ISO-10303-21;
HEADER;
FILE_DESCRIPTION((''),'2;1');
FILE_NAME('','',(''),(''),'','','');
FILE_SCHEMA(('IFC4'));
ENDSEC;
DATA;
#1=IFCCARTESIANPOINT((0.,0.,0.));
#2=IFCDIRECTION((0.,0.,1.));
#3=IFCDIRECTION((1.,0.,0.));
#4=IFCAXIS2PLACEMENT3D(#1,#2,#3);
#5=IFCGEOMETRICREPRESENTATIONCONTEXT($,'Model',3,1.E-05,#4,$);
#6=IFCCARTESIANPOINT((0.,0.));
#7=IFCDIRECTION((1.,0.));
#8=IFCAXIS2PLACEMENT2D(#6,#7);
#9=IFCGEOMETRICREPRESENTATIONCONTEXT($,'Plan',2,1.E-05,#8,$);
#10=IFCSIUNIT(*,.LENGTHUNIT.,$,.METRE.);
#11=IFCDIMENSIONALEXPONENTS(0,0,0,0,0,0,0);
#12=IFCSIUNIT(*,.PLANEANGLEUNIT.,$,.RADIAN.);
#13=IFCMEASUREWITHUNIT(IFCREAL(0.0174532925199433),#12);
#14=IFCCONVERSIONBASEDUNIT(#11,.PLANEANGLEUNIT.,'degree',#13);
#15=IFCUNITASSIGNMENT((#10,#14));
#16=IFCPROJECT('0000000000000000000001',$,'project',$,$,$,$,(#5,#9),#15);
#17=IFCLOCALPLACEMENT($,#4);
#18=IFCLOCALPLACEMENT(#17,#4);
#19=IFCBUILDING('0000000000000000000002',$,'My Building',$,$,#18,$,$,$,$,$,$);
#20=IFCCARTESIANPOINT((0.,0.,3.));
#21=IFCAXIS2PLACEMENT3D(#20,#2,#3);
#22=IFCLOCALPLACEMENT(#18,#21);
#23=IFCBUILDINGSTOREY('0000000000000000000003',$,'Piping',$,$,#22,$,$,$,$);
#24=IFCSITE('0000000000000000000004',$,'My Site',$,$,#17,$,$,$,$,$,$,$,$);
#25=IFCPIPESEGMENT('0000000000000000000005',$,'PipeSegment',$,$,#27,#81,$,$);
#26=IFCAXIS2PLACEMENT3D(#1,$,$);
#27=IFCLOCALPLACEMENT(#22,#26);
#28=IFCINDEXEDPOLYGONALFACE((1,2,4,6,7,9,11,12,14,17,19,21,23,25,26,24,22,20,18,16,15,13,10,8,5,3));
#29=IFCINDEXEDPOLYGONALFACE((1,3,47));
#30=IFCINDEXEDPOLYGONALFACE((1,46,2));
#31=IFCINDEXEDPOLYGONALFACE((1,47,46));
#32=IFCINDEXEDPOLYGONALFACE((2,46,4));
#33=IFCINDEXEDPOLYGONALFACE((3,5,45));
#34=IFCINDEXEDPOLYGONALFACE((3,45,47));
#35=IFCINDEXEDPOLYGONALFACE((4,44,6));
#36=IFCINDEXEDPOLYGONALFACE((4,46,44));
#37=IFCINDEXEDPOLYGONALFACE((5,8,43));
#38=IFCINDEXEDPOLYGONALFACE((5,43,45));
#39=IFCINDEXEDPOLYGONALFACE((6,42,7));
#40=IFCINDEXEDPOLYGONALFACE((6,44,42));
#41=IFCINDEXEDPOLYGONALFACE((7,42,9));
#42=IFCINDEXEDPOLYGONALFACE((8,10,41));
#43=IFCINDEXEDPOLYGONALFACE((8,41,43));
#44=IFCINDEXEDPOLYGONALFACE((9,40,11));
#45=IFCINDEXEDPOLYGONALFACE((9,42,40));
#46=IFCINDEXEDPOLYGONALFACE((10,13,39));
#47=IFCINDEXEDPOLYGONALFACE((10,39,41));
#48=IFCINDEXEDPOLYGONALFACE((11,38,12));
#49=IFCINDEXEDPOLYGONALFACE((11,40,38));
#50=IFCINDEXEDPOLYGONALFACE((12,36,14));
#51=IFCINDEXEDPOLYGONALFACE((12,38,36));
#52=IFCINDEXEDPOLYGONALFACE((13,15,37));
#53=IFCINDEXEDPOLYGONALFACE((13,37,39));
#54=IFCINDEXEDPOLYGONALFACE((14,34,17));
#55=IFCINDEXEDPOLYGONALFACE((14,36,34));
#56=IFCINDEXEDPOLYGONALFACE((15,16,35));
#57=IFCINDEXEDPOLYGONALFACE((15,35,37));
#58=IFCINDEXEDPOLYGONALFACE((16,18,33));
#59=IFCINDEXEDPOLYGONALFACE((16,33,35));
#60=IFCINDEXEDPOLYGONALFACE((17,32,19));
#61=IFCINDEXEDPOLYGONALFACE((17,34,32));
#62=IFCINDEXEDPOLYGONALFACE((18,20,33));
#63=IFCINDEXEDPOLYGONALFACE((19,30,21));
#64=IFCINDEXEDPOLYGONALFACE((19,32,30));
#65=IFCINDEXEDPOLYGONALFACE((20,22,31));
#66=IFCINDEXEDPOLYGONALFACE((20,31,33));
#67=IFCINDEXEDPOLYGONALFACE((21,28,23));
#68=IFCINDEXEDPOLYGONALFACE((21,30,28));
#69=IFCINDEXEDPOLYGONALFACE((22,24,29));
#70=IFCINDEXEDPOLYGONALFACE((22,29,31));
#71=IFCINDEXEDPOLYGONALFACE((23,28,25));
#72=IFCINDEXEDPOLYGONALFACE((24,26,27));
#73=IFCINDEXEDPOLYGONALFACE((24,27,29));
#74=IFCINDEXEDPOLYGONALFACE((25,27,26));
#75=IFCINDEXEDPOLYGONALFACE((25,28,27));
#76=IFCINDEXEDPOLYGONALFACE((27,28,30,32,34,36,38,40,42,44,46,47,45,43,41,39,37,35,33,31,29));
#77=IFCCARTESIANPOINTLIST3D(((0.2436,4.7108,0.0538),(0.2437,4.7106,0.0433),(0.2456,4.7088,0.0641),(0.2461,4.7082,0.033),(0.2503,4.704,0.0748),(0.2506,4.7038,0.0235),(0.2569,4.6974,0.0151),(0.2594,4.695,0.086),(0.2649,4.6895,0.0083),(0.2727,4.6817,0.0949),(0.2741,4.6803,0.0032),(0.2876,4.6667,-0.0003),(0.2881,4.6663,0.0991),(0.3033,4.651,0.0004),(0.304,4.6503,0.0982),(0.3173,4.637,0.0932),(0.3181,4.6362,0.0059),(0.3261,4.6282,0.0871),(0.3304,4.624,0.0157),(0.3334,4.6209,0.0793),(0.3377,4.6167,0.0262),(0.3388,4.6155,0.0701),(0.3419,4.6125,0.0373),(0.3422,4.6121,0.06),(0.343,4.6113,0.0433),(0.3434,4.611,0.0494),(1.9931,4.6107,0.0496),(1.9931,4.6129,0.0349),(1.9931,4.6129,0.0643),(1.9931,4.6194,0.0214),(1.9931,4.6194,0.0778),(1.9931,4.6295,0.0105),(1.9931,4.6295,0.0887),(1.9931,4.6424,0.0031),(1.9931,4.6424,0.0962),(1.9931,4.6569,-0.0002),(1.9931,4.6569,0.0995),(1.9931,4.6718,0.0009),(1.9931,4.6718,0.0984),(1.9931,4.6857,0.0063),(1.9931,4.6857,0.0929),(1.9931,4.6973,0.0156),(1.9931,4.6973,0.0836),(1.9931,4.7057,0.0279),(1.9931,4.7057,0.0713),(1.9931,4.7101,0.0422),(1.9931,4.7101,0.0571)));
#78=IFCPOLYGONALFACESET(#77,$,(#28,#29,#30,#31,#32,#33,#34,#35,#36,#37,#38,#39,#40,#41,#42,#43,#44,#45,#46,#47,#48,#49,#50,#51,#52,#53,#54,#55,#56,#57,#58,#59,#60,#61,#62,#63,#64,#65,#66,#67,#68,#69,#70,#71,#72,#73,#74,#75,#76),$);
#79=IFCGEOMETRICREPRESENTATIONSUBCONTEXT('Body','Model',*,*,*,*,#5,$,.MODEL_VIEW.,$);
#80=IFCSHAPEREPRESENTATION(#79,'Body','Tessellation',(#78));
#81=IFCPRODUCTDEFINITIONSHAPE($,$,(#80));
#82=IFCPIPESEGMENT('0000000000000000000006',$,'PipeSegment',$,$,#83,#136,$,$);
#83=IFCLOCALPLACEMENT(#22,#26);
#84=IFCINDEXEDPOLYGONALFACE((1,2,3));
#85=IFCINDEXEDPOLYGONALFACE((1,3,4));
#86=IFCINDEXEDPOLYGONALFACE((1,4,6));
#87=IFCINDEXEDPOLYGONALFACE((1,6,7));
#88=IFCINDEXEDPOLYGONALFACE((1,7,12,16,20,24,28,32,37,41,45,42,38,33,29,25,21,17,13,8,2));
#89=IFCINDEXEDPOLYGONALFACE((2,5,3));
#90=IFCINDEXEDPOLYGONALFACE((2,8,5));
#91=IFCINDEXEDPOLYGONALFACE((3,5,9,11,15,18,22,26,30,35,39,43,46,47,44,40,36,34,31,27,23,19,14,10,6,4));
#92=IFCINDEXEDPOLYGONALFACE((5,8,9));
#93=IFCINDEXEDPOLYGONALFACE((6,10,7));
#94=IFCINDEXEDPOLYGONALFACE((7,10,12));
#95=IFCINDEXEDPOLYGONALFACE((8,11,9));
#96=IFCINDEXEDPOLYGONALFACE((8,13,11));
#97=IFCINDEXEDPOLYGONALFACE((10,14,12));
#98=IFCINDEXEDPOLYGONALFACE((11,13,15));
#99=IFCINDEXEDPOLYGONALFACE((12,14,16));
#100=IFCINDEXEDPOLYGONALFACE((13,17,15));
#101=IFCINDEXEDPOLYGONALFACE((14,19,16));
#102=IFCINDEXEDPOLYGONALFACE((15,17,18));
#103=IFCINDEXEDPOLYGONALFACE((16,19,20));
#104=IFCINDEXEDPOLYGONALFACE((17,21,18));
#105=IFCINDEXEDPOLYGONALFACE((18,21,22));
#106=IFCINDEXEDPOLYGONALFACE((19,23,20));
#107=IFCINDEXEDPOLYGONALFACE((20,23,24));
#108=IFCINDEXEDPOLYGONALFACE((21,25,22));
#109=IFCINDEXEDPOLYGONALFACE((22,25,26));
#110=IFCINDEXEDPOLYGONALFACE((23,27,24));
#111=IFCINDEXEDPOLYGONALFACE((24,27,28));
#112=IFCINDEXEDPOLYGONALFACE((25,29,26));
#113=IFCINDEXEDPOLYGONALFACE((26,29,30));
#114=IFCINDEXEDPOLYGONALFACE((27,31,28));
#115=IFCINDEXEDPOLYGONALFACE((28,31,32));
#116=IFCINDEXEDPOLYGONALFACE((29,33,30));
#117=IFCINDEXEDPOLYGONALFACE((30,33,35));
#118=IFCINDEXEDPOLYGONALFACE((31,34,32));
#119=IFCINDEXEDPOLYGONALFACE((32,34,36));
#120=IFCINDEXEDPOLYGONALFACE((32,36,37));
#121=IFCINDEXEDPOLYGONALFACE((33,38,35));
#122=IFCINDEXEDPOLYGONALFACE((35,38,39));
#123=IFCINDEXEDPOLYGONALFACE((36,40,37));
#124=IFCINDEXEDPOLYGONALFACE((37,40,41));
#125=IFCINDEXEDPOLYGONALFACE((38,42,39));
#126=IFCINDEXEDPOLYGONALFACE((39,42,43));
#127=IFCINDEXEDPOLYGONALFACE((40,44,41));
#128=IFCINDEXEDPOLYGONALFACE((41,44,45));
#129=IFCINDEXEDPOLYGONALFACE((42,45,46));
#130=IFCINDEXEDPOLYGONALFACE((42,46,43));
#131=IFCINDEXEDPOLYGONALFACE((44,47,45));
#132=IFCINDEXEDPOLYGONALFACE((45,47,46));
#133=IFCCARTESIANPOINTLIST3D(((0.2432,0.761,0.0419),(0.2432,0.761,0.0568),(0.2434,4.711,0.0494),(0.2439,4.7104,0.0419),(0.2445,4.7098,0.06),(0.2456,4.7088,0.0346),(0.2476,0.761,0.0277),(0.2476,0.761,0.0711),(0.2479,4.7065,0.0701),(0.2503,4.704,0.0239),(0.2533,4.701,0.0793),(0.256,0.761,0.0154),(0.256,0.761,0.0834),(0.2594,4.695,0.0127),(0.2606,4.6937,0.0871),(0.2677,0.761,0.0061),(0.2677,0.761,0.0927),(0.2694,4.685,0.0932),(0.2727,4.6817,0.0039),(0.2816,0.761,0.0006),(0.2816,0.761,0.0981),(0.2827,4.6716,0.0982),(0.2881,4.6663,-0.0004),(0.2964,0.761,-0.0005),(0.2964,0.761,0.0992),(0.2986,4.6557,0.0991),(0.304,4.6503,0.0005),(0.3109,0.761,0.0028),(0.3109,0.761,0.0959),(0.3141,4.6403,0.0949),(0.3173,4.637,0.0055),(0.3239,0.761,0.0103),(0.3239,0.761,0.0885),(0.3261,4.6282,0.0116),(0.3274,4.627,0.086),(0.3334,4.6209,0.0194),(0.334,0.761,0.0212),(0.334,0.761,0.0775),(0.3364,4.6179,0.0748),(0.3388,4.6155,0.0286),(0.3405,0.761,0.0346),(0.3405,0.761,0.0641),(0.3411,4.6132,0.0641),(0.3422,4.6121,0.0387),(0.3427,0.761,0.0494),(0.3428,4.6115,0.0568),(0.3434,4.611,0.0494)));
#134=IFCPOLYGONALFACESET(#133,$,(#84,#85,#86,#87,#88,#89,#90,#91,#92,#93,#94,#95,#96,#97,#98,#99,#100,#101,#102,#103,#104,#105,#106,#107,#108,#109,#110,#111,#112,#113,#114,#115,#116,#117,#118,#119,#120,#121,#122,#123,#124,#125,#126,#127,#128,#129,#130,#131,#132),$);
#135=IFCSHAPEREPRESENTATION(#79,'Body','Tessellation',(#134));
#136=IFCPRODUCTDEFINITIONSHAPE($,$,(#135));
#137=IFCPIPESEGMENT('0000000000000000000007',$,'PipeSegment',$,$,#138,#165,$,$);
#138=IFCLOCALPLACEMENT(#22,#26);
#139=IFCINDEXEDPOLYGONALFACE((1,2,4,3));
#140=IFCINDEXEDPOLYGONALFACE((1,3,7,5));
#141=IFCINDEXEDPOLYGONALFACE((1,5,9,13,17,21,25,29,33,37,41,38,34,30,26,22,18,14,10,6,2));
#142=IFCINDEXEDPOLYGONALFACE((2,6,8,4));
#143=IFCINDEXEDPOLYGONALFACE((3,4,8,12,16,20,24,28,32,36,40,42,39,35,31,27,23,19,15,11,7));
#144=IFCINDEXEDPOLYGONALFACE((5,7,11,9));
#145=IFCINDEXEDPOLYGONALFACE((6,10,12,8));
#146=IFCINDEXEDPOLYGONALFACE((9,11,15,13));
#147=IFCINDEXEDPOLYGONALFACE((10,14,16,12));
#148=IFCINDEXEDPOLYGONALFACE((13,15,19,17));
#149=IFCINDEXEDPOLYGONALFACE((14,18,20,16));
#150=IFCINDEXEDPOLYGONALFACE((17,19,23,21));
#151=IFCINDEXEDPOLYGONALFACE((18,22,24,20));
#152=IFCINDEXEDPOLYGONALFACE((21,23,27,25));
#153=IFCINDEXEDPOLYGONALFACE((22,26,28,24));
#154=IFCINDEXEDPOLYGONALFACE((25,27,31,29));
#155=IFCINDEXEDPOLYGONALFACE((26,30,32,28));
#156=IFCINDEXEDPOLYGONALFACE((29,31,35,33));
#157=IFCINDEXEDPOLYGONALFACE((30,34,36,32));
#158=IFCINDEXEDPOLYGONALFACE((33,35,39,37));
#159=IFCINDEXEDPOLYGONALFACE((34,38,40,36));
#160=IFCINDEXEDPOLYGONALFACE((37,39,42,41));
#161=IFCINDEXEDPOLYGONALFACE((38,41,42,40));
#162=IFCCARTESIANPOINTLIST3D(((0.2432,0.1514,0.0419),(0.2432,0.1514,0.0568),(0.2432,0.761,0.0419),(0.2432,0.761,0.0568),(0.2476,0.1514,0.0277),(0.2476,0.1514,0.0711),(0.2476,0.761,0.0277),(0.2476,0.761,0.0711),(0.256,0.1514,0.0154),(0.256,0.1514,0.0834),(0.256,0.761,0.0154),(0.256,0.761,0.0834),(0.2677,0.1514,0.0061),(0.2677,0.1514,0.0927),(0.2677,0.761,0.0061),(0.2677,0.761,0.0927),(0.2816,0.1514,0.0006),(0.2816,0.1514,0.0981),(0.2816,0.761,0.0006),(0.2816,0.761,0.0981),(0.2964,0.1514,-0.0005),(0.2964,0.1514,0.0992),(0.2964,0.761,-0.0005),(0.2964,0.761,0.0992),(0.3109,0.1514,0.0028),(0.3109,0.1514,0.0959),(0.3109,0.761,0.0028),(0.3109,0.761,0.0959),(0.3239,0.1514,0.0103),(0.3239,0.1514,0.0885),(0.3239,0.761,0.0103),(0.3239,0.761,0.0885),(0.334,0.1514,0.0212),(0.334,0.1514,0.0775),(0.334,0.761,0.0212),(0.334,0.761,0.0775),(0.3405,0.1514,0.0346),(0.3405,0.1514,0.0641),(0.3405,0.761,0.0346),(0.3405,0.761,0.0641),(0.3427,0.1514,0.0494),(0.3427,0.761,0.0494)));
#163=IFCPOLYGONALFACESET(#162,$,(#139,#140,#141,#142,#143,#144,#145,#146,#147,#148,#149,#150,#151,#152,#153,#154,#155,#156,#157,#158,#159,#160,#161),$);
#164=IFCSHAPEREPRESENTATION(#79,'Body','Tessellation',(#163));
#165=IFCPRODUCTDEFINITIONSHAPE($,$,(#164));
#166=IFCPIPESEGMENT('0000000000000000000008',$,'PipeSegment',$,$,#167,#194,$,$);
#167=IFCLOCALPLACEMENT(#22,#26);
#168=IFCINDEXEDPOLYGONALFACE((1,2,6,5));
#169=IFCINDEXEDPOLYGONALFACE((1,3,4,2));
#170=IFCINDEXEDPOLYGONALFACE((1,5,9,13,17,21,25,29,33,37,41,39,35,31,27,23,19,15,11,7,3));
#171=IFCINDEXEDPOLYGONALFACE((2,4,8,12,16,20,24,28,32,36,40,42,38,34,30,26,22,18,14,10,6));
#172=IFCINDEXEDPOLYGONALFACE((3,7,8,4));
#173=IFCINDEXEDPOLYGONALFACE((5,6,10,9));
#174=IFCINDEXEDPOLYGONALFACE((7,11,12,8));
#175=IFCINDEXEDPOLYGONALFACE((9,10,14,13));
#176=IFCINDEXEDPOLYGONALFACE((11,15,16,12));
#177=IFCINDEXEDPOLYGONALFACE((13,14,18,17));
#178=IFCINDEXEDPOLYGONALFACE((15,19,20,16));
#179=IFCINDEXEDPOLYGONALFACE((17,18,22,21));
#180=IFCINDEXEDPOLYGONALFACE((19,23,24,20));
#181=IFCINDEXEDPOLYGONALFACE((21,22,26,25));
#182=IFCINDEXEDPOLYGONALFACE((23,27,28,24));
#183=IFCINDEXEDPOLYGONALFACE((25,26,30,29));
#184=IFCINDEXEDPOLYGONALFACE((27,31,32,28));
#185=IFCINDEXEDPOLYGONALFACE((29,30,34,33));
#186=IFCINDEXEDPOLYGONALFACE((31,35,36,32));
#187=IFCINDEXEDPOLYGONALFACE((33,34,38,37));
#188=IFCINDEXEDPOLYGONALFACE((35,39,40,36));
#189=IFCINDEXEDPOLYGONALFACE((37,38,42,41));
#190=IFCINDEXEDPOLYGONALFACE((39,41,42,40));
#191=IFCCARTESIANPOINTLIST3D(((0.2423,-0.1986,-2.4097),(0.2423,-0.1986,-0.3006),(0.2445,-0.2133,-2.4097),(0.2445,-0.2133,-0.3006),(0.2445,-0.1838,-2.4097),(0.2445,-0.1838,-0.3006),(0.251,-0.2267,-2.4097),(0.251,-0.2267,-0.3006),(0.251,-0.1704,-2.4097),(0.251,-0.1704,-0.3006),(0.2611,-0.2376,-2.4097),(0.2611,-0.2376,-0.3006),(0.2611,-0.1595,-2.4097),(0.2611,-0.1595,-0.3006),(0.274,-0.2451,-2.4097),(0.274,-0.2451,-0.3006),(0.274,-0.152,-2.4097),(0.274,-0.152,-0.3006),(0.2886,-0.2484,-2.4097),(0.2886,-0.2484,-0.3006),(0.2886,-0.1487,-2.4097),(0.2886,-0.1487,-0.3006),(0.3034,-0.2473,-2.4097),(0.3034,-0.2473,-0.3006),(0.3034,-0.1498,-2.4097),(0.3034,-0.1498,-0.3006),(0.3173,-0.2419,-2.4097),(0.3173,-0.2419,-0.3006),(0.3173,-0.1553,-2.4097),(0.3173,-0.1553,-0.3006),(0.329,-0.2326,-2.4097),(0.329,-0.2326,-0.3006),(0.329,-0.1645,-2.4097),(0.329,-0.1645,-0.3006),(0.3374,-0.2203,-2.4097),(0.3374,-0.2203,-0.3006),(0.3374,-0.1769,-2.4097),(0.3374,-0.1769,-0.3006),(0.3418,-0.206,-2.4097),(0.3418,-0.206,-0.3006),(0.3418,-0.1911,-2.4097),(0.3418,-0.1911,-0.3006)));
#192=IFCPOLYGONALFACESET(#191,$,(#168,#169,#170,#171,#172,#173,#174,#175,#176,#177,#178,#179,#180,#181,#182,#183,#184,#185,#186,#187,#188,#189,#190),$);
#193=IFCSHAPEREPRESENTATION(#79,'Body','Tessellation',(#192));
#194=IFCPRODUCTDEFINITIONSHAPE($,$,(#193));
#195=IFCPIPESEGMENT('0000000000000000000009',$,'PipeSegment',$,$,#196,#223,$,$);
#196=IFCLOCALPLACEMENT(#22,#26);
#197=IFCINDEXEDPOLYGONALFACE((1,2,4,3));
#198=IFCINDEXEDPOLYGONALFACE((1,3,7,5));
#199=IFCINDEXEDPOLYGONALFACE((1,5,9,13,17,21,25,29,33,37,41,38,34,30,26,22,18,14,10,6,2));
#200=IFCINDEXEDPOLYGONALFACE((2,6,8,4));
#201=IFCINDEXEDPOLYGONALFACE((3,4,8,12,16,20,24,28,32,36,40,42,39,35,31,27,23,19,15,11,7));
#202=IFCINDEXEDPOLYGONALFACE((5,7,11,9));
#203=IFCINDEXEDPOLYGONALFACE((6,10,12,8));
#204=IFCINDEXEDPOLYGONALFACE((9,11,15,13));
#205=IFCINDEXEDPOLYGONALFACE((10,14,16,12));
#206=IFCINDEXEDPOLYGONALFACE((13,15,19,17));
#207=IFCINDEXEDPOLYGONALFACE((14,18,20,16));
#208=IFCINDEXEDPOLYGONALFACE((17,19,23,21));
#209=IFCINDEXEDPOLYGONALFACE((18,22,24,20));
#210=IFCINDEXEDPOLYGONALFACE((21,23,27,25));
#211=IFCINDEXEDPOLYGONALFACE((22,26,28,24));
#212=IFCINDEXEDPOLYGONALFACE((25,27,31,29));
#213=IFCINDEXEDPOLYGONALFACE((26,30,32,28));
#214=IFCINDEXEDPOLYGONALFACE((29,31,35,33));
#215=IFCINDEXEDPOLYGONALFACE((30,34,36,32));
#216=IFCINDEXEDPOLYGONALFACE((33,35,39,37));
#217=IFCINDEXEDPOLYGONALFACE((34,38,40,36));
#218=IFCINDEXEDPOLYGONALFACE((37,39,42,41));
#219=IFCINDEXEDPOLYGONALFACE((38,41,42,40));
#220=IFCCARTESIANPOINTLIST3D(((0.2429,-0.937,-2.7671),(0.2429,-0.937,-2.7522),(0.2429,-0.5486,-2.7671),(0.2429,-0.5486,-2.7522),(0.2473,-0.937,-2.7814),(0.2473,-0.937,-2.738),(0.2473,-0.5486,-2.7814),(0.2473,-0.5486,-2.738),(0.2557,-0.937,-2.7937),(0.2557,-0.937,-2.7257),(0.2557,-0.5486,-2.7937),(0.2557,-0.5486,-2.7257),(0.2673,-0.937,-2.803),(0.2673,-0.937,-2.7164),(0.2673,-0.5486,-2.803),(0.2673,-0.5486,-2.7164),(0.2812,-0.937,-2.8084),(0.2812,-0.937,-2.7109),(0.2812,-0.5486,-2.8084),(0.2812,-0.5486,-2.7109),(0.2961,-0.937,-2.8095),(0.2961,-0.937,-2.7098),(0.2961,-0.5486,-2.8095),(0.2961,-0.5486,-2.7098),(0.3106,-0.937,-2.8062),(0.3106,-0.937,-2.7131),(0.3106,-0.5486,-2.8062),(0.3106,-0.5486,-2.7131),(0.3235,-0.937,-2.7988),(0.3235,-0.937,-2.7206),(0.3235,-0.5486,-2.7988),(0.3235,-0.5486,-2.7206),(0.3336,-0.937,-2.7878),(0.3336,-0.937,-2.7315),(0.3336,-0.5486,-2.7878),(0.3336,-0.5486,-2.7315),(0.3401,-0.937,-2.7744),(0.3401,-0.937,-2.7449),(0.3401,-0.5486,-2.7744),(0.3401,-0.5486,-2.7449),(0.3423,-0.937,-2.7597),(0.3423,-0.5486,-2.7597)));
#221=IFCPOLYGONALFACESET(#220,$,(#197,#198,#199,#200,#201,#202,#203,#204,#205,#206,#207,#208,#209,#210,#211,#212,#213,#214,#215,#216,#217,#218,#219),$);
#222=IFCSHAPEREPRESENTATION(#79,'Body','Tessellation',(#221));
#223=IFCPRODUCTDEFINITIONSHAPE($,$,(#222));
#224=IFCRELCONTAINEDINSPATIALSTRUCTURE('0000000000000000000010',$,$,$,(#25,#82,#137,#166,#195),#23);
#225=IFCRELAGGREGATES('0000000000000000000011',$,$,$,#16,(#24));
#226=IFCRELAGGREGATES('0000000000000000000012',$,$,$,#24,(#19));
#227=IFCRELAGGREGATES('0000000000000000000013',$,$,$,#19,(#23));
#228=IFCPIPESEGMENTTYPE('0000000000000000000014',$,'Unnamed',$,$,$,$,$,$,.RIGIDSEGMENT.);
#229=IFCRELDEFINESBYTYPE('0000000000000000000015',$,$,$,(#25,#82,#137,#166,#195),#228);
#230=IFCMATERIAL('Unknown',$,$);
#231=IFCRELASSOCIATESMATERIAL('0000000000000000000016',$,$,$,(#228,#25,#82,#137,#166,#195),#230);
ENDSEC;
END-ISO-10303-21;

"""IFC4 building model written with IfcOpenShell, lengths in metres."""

from ifc_helpers import new_model, entity, si_unit, converted_unit, frame, origin_with_axes, origin_2d_with_axis, place, context, subcontext, project, spatial, circle, extrude, clip, halfspace, material, material_profile, profile_set, profile_usage, type_object, element, save


model = new_model("IFC4")

# Units and contexts
model_context = context("Model", 3, precision=1e-05, world=origin_with_axes())
plan_context = context("Plan", 2, precision=1e-05, world=origin_2d_with_axis())
body_context = subcontext(model_context, "Body", "Model", "MODEL_VIEW")
ifc_project = project(units=[si_unit("LENGTHUNIT", "METRE"), converted_unit("PLANEANGLEUNIT", "degree", entity("IfcReal", 0.0174532925199433), si_unit("PLANEANGLEUNIT", "RADIAN"), dimensions=[0, 0, 0, 0, 0, 0, 0])], contexts=[model_context, plan_context])

# Site, building, storey
site_placement = place(None, origin_with_axes())
site = spatial("IfcSite", under=ifc_project, at=site_placement, Name="My Site")
building_placement = place(site_placement, origin_with_axes())
building = spatial("IfcBuilding", under=site, at=building_placement, Name="My Building")
storey_placement = place(building_placement, frame((0.0, 0.0, 3.0), z_axis=(0.0, 0.0, 1.0), x_axis=(1.0, 0.0, 0.0)))
storey = spatial("IfcBuildingStorey", under=building, at=storey_placement, Name="Piping")

# Pipe segments
ifc_material = material(Name="Unknown")
ifc_material_profile = material_profile(ifc_material, circle(Radius=0.05))
ifc_profile_set = profile_set([ifc_material_profile])
pipe_segment_type = type_object("IfcPipeSegmentType", Name="Unnamed", PredefinedType="RIGIDSEGMENT", material=ifc_profile_set)
ifc_profile_usage_1 = profile_usage(ifc_profile_set, cardinal=5)
pipe_segment_1_placement = place(storey_placement, frame((1.9931, 4.6607, 0.0496), z_axis=(-1.0, 0.000174, -0.000145), x_axis=(-0.000174, -1.0, 0.0)))
element("IfcPipeSegment", 1, at=pipe_segment_1_placement, inside=storey, type_object=pipe_segment_type, material=ifc_profile_usage_1, Name="PipeSegment", context=body_context, shape_type="Clipping", body=[
    clip(extrude(circle(Radius=0.05), origin_with_axes(), (0.0, 0.0, 1.0), 1.8497), halfspace(frame((-0.05, -3.099, 1.7502), z_axis=(0.707106, 0.000103, 0.707107), x_axis=(0.000145, -1.0, 0.0)), False)),
])
ifc_profile_usage_2 = profile_usage(ifc_profile_set, cardinal=5)
pipe_segment_2_placement = place(storey_placement, frame((0.2934, 4.711, 0.0494), z_axis=(-0.000174, -1.0, 0.0), x_axis=(1.0, -0.000174, 0.0)))
element("IfcPipeSegment", 2, at=pipe_segment_2_placement, inside=storey, type_object=pipe_segment_type, material=ifc_profile_usage_2, Name="PipeSegment", context=body_context, shape_type="Clipping", body=[
    clip(extrude(circle(Radius=0.05), origin_with_axes(), (0.0, 0.0, 1.0), 3.95), halfspace(frame((-0.05, -3.099, 0.0), z_axis=(0.707107, 0.0, -0.707106), x_axis=(0.0, -1.0, 0.0)), False)),
])
ifc_profile_usage_3 = profile_usage(ifc_profile_set, cardinal=5)
pipe_segment_3_placement = place(storey_placement, frame((0.2927, 0.761, 0.0494), z_axis=(0.0, -1.0, 0.0), x_axis=(1.0, 0.0, 0.0)))
element("IfcPipeSegment", 3, at=pipe_segment_3_placement, inside=storey, type_object=pipe_segment_type, material=ifc_profile_usage_3, Name="PipeSegment", context=body_context, shape_type="SweptSolid", body=[
    extrude(circle(Radius=0.05), origin_with_axes(), (0.0, 0.0, 1.0), 0.6095),
])
ifc_profile_usage_4 = profile_usage(ifc_profile_set, cardinal=5)
pipe_segment_4_placement = place(storey_placement, frame((0.2923, -0.1986, -0.3006), z_axis=(0.0, 0.0, -1.0), x_axis=(-1.0, 0.0, 0.0)))
element("IfcPipeSegment", 4, at=pipe_segment_4_placement, inside=storey, type_object=pipe_segment_type, material=ifc_profile_usage_4, Name="PipeSegment", context=body_context, shape_type="SweptSolid", body=[
    extrude(circle(Radius=0.05), origin_with_axes(), (0.0, 0.0, 1.0), 2.109),
])
ifc_profile_usage_5 = profile_usage(ifc_profile_set, cardinal=5)
pipe_segment_5_placement = place(storey_placement, frame((0.2923, -0.5486, -2.7597), z_axis=(0.0, -1.0, 0.0), x_axis=(1.0, 0.0, 0.0)))
element("IfcPipeSegment", 5, at=pipe_segment_5_placement, inside=storey, type_object=pipe_segment_type, material=ifc_profile_usage_5, Name="PipeSegment", context=body_context, shape_type="SweptSolid", body=[
    extrude(circle(Radius=0.05), origin_with_axes(), (0.0, 0.0, 1.0), 0.3884),
])

save(model, "model.ifc")
